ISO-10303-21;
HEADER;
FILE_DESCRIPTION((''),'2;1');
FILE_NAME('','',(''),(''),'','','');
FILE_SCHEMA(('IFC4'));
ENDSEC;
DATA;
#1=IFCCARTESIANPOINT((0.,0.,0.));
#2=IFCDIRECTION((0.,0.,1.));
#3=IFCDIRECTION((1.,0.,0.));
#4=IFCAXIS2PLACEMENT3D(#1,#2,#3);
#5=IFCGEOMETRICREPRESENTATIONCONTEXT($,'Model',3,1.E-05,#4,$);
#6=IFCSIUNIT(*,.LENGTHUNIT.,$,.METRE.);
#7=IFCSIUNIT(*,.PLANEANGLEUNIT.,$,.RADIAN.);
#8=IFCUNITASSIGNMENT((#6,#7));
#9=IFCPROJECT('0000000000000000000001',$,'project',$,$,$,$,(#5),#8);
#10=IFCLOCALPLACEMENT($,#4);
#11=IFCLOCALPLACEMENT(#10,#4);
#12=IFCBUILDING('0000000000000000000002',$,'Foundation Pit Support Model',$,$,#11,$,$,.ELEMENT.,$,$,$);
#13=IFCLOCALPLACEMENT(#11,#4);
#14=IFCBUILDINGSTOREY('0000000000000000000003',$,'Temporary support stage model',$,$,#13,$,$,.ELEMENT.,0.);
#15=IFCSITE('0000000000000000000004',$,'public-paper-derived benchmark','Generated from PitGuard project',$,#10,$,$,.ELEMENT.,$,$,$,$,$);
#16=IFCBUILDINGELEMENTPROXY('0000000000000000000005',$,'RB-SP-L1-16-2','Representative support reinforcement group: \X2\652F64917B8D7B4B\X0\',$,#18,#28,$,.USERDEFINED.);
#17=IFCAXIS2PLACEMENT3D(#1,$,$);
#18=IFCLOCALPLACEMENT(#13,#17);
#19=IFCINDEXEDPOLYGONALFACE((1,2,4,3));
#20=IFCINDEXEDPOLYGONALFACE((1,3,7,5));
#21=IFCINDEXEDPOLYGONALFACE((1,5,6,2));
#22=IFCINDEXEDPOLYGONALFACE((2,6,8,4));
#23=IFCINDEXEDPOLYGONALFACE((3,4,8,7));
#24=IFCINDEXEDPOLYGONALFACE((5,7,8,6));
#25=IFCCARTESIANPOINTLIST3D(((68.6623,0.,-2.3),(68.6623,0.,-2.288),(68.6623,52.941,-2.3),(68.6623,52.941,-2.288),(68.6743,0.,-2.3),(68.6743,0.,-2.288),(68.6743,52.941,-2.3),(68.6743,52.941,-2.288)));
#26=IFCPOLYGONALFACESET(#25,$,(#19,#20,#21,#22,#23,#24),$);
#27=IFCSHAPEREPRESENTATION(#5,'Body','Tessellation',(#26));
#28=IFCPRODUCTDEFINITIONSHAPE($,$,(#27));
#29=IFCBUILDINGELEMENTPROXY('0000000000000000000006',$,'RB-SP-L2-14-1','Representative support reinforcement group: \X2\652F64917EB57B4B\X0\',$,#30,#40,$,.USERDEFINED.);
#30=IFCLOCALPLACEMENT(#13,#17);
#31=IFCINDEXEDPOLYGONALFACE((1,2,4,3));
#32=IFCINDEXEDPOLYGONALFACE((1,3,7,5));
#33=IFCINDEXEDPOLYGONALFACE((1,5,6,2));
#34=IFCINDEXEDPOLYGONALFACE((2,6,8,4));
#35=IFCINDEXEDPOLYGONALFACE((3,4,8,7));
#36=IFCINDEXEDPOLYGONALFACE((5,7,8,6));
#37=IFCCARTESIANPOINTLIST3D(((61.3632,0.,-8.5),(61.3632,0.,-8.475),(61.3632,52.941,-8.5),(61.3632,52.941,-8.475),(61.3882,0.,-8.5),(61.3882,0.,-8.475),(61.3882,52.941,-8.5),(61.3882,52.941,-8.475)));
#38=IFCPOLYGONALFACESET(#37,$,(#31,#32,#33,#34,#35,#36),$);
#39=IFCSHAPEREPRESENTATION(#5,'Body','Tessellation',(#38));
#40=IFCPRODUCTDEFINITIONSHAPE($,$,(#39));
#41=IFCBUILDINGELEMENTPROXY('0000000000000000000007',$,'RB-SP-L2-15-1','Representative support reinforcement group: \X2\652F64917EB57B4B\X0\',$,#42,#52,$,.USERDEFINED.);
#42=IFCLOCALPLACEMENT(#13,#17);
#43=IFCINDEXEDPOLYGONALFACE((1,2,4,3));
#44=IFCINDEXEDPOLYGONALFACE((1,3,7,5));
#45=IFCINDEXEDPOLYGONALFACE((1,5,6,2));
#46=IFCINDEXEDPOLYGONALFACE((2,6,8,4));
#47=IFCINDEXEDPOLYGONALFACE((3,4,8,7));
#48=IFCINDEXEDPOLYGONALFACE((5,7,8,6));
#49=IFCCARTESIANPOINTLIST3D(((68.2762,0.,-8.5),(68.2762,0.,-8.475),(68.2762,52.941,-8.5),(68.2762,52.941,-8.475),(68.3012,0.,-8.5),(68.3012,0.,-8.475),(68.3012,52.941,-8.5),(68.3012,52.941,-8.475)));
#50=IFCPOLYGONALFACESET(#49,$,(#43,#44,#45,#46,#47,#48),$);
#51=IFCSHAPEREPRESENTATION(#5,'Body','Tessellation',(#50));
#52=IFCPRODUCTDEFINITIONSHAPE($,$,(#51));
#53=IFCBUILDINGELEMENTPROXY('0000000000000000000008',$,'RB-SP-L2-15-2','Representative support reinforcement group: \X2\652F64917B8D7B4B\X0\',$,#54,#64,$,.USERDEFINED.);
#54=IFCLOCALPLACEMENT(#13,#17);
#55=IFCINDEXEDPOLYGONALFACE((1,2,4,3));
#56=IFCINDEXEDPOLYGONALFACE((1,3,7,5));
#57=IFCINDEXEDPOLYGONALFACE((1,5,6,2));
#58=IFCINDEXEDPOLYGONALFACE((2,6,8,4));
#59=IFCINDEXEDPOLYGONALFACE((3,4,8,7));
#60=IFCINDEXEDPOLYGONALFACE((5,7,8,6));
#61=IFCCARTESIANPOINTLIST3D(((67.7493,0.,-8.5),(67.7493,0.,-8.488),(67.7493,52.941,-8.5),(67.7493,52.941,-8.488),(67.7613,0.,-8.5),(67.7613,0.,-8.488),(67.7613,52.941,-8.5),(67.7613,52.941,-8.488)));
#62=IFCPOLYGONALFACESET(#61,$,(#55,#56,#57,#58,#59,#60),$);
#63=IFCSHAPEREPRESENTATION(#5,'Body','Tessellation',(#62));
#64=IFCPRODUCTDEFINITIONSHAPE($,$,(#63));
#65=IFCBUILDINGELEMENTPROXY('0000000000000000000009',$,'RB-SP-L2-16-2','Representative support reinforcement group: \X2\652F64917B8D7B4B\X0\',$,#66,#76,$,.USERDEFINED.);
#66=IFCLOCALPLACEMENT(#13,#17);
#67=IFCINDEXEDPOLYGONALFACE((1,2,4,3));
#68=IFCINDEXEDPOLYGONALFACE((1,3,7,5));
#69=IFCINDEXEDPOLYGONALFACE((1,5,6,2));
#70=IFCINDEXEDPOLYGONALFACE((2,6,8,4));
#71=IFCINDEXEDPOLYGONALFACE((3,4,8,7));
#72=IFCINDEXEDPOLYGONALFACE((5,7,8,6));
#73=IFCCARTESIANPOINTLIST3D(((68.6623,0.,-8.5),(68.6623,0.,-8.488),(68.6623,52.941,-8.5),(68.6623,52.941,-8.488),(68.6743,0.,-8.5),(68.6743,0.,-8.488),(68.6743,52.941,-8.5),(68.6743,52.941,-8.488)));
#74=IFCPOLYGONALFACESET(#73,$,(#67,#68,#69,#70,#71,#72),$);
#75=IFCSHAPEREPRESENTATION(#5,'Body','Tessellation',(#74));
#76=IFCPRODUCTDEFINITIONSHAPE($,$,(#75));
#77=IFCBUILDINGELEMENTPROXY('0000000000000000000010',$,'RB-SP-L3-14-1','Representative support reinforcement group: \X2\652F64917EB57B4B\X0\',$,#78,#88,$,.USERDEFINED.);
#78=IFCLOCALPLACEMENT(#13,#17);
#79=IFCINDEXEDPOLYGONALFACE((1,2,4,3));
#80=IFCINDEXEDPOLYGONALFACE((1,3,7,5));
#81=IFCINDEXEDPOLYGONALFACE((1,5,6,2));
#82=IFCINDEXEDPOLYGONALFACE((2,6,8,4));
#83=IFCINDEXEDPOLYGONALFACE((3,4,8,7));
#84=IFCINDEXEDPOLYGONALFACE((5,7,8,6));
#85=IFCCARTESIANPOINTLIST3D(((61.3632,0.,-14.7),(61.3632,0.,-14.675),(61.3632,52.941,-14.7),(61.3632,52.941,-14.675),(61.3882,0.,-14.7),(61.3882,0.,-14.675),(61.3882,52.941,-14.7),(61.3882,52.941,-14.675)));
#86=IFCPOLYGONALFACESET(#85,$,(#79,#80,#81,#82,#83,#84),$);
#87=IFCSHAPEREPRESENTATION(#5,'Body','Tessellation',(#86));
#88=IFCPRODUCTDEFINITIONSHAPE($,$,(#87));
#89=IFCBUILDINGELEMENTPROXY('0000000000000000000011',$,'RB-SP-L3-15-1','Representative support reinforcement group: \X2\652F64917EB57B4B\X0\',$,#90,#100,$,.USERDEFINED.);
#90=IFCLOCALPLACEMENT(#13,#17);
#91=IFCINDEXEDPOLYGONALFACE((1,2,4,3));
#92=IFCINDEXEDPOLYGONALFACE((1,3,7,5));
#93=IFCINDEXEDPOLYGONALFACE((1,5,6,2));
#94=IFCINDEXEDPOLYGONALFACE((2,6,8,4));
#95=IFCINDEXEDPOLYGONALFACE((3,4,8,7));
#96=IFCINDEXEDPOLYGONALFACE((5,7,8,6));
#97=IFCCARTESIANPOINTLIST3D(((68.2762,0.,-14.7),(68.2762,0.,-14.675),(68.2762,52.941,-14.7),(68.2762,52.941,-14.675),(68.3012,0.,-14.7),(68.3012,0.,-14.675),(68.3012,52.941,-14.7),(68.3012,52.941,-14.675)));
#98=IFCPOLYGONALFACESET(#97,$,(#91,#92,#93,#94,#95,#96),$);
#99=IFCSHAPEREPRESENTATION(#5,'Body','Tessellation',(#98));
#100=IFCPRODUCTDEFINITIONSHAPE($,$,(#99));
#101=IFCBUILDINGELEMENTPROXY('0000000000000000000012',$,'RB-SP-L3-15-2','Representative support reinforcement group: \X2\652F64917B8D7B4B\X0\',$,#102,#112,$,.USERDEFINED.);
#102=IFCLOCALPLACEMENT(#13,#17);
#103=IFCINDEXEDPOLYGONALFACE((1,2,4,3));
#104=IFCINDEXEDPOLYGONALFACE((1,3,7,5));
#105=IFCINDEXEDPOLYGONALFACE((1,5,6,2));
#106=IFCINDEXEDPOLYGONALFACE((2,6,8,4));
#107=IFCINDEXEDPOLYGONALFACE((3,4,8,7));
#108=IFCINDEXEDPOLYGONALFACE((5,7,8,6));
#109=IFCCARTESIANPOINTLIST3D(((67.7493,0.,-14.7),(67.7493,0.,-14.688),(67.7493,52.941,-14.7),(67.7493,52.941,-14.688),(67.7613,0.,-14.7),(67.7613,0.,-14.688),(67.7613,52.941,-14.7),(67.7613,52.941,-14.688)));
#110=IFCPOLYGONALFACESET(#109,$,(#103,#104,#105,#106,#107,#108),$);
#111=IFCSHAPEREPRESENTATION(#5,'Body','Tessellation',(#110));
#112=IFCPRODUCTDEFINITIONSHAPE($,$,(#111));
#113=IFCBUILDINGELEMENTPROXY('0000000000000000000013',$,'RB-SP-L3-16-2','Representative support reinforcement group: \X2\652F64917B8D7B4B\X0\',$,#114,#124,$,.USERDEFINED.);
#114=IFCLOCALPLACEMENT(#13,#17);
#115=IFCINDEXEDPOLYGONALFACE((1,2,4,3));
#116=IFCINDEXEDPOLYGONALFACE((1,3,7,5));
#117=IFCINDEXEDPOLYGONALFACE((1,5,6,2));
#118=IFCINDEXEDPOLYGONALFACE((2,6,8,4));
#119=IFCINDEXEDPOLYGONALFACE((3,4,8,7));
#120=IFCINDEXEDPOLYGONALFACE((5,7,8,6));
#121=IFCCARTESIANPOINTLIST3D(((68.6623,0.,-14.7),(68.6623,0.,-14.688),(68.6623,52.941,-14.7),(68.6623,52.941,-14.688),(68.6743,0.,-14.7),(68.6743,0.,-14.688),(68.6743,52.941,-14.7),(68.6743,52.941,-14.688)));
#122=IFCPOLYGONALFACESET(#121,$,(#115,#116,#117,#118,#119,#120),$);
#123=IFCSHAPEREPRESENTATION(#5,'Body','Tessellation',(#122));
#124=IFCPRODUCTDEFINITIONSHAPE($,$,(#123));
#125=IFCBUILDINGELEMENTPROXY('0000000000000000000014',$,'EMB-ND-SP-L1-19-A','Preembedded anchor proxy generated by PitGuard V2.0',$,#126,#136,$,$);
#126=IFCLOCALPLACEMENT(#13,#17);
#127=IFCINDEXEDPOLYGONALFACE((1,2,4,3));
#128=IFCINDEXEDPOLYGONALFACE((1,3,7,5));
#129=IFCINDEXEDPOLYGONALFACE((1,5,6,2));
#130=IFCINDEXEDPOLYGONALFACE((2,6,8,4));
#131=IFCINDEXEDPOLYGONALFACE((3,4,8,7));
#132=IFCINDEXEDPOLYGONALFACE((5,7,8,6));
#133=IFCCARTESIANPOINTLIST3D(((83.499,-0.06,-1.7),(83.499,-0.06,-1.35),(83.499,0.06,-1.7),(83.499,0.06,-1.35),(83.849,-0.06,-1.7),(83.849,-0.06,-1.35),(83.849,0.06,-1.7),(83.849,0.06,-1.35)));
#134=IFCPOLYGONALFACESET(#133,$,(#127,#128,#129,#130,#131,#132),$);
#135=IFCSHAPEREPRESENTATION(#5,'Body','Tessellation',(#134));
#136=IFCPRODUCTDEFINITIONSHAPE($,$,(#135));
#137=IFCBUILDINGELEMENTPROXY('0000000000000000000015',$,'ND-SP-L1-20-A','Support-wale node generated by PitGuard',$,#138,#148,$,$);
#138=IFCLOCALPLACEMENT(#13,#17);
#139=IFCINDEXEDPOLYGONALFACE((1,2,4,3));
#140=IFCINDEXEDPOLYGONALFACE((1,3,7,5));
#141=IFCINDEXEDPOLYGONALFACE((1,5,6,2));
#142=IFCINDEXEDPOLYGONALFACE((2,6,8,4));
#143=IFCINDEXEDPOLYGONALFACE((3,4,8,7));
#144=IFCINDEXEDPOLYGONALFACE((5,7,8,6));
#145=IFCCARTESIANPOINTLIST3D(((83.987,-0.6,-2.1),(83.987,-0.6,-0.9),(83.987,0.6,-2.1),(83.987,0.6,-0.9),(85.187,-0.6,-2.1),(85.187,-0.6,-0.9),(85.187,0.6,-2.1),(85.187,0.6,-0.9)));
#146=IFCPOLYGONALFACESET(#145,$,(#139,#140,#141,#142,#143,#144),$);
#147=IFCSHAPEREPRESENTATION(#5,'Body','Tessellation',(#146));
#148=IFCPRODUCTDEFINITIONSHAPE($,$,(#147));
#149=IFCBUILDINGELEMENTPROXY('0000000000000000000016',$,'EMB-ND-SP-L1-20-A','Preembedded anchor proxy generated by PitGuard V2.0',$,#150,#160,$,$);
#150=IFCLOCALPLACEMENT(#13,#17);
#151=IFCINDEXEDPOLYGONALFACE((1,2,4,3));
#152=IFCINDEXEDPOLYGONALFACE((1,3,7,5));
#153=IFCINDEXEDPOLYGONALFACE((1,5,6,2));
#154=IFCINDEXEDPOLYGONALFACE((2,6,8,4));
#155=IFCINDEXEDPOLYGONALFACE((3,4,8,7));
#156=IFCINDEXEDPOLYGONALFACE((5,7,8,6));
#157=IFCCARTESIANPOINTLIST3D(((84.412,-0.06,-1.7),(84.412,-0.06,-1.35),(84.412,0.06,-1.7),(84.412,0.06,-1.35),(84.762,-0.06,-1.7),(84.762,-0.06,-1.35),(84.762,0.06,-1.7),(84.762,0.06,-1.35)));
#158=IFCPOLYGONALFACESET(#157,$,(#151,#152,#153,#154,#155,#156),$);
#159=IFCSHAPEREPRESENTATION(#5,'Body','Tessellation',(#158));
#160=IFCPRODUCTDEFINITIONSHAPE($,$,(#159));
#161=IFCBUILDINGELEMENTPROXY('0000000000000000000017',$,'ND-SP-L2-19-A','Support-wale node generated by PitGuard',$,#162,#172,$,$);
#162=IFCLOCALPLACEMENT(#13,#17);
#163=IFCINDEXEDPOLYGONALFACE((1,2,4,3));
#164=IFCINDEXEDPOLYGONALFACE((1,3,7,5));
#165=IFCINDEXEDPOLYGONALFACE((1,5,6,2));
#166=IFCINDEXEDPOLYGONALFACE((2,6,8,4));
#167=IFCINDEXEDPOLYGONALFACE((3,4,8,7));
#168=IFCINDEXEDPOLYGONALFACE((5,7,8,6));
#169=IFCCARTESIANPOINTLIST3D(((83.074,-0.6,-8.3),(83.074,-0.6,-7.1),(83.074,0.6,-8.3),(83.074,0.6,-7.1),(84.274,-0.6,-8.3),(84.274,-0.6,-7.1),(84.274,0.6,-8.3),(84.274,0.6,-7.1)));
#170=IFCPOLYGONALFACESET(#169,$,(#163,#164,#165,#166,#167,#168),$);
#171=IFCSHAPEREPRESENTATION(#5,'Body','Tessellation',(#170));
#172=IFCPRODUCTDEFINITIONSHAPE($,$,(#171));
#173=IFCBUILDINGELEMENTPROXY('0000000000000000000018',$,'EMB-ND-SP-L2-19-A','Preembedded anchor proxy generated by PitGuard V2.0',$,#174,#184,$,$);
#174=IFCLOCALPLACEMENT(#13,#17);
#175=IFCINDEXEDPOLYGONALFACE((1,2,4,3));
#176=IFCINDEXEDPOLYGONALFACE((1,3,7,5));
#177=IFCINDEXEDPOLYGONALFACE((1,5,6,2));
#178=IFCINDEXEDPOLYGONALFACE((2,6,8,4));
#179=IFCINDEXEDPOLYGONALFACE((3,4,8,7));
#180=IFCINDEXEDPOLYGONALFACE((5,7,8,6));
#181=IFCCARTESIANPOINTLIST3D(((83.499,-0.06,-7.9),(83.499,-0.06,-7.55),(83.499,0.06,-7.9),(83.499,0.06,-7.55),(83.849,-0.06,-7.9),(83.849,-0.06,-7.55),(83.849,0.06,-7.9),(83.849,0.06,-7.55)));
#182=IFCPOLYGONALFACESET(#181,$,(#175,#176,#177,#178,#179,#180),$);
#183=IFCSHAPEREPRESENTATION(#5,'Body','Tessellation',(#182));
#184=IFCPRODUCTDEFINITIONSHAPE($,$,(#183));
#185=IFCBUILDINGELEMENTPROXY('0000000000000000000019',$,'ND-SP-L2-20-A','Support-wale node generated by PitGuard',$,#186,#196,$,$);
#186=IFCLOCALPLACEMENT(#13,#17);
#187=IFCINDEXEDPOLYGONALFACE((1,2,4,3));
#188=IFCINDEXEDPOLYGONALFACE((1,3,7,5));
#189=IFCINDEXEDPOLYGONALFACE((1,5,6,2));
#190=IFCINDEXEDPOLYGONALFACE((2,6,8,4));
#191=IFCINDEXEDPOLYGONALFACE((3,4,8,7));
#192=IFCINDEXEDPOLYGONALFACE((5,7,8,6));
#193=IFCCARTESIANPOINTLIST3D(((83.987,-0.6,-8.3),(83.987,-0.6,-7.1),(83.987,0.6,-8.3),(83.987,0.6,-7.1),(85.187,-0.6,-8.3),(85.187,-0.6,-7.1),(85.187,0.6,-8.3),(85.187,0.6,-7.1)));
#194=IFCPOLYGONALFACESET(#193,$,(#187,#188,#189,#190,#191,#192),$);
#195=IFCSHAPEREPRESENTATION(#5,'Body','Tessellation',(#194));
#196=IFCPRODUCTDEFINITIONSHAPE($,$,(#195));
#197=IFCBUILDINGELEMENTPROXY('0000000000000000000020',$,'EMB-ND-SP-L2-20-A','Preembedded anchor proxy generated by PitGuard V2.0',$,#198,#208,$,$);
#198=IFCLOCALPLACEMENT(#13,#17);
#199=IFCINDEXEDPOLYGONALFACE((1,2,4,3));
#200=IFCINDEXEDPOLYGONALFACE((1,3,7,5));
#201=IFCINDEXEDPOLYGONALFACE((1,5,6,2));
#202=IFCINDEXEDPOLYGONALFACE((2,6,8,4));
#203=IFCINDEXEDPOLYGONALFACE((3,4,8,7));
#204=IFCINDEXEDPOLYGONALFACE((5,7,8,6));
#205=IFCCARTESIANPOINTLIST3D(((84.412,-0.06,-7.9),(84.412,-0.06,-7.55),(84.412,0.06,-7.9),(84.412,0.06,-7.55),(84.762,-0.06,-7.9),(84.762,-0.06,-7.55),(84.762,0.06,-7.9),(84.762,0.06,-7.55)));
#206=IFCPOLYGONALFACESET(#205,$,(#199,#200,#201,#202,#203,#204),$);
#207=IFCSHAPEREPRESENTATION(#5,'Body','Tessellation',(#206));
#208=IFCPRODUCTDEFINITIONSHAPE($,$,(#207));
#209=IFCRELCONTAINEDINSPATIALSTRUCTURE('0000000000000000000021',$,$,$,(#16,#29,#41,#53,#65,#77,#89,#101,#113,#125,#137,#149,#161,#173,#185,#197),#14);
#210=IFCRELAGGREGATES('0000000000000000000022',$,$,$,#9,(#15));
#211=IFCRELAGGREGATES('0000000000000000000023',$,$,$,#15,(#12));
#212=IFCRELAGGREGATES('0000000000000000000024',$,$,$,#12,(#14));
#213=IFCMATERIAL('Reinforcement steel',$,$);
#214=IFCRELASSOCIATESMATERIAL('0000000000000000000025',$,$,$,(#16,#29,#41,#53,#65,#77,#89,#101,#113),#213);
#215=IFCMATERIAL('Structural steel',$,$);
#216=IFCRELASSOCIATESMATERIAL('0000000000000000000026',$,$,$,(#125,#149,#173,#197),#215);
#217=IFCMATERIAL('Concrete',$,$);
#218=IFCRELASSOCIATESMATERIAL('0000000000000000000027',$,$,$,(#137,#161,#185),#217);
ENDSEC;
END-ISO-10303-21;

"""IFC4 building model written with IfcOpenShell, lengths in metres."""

from ifc_helpers import new_model, si_unit, frame, origin_with_axes, origin_2d, place, context, project, spatial, rectangle, extrude, material, element, save


model = new_model("IFC4")

# Units and contexts
model_context = context("Model", 3, precision=1e-05, world=origin_with_axes())
ifc_project = project(units=[si_unit("LENGTHUNIT", "METRE"), si_unit("PLANEANGLEUNIT", "RADIAN")], contexts=[model_context])

# Site, building, storey
site_placement = place(None, origin_with_axes())
site = spatial("IfcSite", under=ifc_project, at=site_placement, Name="public-paper-derived benchmark", Description="Generated from PitGuard project", CompositionType="ELEMENT")
building_placement = place(site_placement, origin_with_axes())
building = spatial("IfcBuilding", under=site, at=building_placement, Name="Foundation Pit Support Model", CompositionType="ELEMENT")
storey_placement = place(building_placement, origin_with_axes())
storey = spatial("IfcBuildingStorey", under=building, at=storey_placement, Name="Temporary support stage model", CompositionType="ELEMENT", Elevation=0.0)

# Shared definitions
ifc_material_1 = material(Name="Structural steel")

# Shared definitions
ifc_material_2 = material(Name="Concrete")

# Building element proxies
ifc_material_3 = material(Name="Reinforcement steel")
for number, where, z_axis, x_axis, name in (
    (1, (68.6683, 26.4705, -2.3), (0.0, 0.0, 1.0), (0.0, 1.0, 0.0), "RB-SP-L1-16-2"),
):
    element("IfcBuildingElementProxy", number, at=place(storey_placement, frame(where, z_axis=z_axis, x_axis=x_axis)), inside=storey, material=ifc_material_3, Name=name, Description="Representative support reinforcement group: 支撑箍筋", PredefinedType="USERDEFINED", context=model_context, shape_type="SweptSolid", body=[
        extrude(rectangle(XDim=52.941, YDim=0.012, at=origin_2d()), origin_with_axes(), (0.0, 0.0, 1.0), 0.012),
    ])
for number, where, z_axis, x_axis, name in (
    (2, (61.3757, 26.4705, -8.5), (0.0, 0.0, 1.0), (0.0, 1.0, 0.0), "RB-SP-L2-14-1"),
    (3, (68.2887, 26.4705, -8.5), (0.0, 0.0, 1.0), (0.0, 1.0, 0.0), "RB-SP-L2-15-1"),
):
    element("IfcBuildingElementProxy", number, at=place(storey_placement, frame(where, z_axis=z_axis, x_axis=x_axis)), inside=storey, material=ifc_material_3, Name=name, Description="Representative support reinforcement group: 支撑纵筋", PredefinedType="USERDEFINED", context=model_context, shape_type="SweptSolid", body=[
        extrude(rectangle(XDim=52.941, YDim=0.025, at=origin_2d()), origin_with_axes(), (0.0, 0.0, 1.0), 0.025),
    ])
for number, where, z_axis, x_axis, name in (
    (4, (67.7553, 26.4705, -8.5), (0.0, 0.0, 1.0), (0.0, 1.0, 0.0), "RB-SP-L2-15-2"),
    (5, (68.6683, 26.4705, -8.5), (0.0, 0.0, 1.0), (0.0, 1.0, 0.0), "RB-SP-L2-16-2"),
):
    element("IfcBuildingElementProxy", number, at=place(storey_placement, frame(where, z_axis=z_axis, x_axis=x_axis)), inside=storey, material=ifc_material_3, Name=name, Description="Representative support reinforcement group: 支撑箍筋", PredefinedType="USERDEFINED", context=model_context, shape_type="SweptSolid", body=[
        extrude(rectangle(XDim=52.941, YDim=0.012, at=origin_2d()), origin_with_axes(), (0.0, 0.0, 1.0), 0.012),
    ])
for number, where, z_axis, x_axis, name in (
    (6, (61.3757, 26.4705, -14.7), (0.0, 0.0, 1.0), (0.0, 1.0, 0.0), "RB-SP-L3-14-1"),
    (7, (68.2887, 26.4705, -14.7), (0.0, 0.0, 1.0), (0.0, 1.0, 0.0), "RB-SP-L3-15-1"),
):
    element("IfcBuildingElementProxy", number, at=place(storey_placement, frame(where, z_axis=z_axis, x_axis=x_axis)), inside=storey, material=ifc_material_3, Name=name, Description="Representative support reinforcement group: 支撑纵筋", PredefinedType="USERDEFINED", context=model_context, shape_type="SweptSolid", body=[
        extrude(rectangle(XDim=52.941, YDim=0.025, at=origin_2d()), origin_with_axes(), (0.0, 0.0, 1.0), 0.025),
    ])
for number, where, z_axis, x_axis, name in (
    (8, (67.7553, 26.4705, -14.7), (0.0, 0.0, 1.0), (0.0, 1.0, 0.0), "RB-SP-L3-15-2"),
    (9, (68.6683, 26.4705, -14.7), (0.0, 0.0, 1.0), (0.0, 1.0, 0.0), "RB-SP-L3-16-2"),
):
    element("IfcBuildingElementProxy", number, at=place(storey_placement, frame(where, z_axis=z_axis, x_axis=x_axis)), inside=storey, material=ifc_material_3, Name=name, Description="Representative support reinforcement group: 支撑箍筋", PredefinedType="USERDEFINED", context=model_context, shape_type="SweptSolid", body=[
        extrude(rectangle(XDim=52.941, YDim=0.012, at=origin_2d()), origin_with_axes(), (0.0, 0.0, 1.0), 0.012),
    ])
proxy_1_placement = place(storey_placement, frame((83.674, 0.0, -1.7), z_axis=(0.0, 0.0, 1.0), x_axis=(1.0, 0.0, 0.0)))
element("IfcBuildingElementProxy", 10, at=proxy_1_placement, inside=storey, material=ifc_material_1, Name="EMB-ND-SP-L1-19-A", Description="Preembedded anchor proxy generated by PitGuard V2.0", context=model_context, shape_type="SweptSolid", body=[
    extrude(rectangle(XDim=0.35, YDim=0.12, at=origin_2d()), origin_with_axes(), (0.0, 0.0, 1.0), 0.35),
])
proxy_2_placement = place(storey_placement, frame((84.587, 0.0, -2.1), z_axis=(0.0, 0.0, 1.0), x_axis=(1.0, 0.0, 0.0)))
element("IfcBuildingElementProxy", 11, at=proxy_2_placement, inside=storey, material=ifc_material_2, Name="ND-SP-L1-20-A", Description="Support-wale node generated by PitGuard", context=model_context, shape_type="SweptSolid", body=[
    extrude(rectangle(XDim=1.2, YDim=1.2, at=origin_2d()), origin_with_axes(), (0.0, 0.0, 1.0), 1.2),
])
proxy_3_placement = place(storey_placement, frame((84.587, 0.0, -1.7), z_axis=(0.0, 0.0, 1.0), x_axis=(1.0, 0.0, 0.0)))
element("IfcBuildingElementProxy", 12, at=proxy_3_placement, inside=storey, material=ifc_material_1, Name="EMB-ND-SP-L1-20-A", Description="Preembedded anchor proxy generated by PitGuard V2.0", context=model_context, shape_type="SweptSolid", body=[
    extrude(rectangle(XDim=0.35, YDim=0.12, at=origin_2d()), origin_with_axes(), (0.0, 0.0, 1.0), 0.35),
])
proxy_4_placement = place(storey_placement, frame((83.674, 0.0, -8.3), z_axis=(0.0, 0.0, 1.0), x_axis=(1.0, 0.0, 0.0)))
element("IfcBuildingElementProxy", 13, at=proxy_4_placement, inside=storey, material=ifc_material_2, Name="ND-SP-L2-19-A", Description="Support-wale node generated by PitGuard", context=model_context, shape_type="SweptSolid", body=[
    extrude(rectangle(XDim=1.2, YDim=1.2, at=origin_2d()), origin_with_axes(), (0.0, 0.0, 1.0), 1.2),
])
proxy_5_placement = place(storey_placement, frame((83.674, 0.0, -7.9), z_axis=(0.0, 0.0, 1.0), x_axis=(1.0, 0.0, 0.0)))
element("IfcBuildingElementProxy", 14, at=proxy_5_placement, inside=storey, material=ifc_material_1, Name="EMB-ND-SP-L2-19-A", Description="Preembedded anchor proxy generated by PitGuard V2.0", context=model_context, shape_type="SweptSolid", body=[
    extrude(rectangle(XDim=0.35, YDim=0.12, at=origin_2d()), origin_with_axes(), (0.0, 0.0, 1.0), 0.35),
])
proxy_6_placement = place(storey_placement, frame((84.587, 0.0, -8.3), z_axis=(0.0, 0.0, 1.0), x_axis=(1.0, 0.0, 0.0)))
element("IfcBuildingElementProxy", 15, at=proxy_6_placement, inside=storey, material=ifc_material_2, Name="ND-SP-L2-20-A", Description="Support-wale node generated by PitGuard", context=model_context, shape_type="SweptSolid", body=[
    extrude(rectangle(XDim=1.2, YDim=1.2, at=origin_2d()), origin_with_axes(), (0.0, 0.0, 1.0), 1.2),
])
proxy_7_placement = place(storey_placement, frame((84.587, 0.0, -7.9), z_axis=(0.0, 0.0, 1.0), x_axis=(1.0, 0.0, 0.0)))
element("IfcBuildingElementProxy", 16, at=proxy_7_placement, inside=storey, material=ifc_material_1, Name="EMB-ND-SP-L2-20-A", Description="Preembedded anchor proxy generated by PitGuard V2.0", context=model_context, shape_type="SweptSolid", body=[
    extrude(rectangle(XDim=0.35, YDim=0.12, at=origin_2d()), origin_with_axes(), (0.0, 0.0, 1.0), 0.35),
])

save(model, "model.ifc")
